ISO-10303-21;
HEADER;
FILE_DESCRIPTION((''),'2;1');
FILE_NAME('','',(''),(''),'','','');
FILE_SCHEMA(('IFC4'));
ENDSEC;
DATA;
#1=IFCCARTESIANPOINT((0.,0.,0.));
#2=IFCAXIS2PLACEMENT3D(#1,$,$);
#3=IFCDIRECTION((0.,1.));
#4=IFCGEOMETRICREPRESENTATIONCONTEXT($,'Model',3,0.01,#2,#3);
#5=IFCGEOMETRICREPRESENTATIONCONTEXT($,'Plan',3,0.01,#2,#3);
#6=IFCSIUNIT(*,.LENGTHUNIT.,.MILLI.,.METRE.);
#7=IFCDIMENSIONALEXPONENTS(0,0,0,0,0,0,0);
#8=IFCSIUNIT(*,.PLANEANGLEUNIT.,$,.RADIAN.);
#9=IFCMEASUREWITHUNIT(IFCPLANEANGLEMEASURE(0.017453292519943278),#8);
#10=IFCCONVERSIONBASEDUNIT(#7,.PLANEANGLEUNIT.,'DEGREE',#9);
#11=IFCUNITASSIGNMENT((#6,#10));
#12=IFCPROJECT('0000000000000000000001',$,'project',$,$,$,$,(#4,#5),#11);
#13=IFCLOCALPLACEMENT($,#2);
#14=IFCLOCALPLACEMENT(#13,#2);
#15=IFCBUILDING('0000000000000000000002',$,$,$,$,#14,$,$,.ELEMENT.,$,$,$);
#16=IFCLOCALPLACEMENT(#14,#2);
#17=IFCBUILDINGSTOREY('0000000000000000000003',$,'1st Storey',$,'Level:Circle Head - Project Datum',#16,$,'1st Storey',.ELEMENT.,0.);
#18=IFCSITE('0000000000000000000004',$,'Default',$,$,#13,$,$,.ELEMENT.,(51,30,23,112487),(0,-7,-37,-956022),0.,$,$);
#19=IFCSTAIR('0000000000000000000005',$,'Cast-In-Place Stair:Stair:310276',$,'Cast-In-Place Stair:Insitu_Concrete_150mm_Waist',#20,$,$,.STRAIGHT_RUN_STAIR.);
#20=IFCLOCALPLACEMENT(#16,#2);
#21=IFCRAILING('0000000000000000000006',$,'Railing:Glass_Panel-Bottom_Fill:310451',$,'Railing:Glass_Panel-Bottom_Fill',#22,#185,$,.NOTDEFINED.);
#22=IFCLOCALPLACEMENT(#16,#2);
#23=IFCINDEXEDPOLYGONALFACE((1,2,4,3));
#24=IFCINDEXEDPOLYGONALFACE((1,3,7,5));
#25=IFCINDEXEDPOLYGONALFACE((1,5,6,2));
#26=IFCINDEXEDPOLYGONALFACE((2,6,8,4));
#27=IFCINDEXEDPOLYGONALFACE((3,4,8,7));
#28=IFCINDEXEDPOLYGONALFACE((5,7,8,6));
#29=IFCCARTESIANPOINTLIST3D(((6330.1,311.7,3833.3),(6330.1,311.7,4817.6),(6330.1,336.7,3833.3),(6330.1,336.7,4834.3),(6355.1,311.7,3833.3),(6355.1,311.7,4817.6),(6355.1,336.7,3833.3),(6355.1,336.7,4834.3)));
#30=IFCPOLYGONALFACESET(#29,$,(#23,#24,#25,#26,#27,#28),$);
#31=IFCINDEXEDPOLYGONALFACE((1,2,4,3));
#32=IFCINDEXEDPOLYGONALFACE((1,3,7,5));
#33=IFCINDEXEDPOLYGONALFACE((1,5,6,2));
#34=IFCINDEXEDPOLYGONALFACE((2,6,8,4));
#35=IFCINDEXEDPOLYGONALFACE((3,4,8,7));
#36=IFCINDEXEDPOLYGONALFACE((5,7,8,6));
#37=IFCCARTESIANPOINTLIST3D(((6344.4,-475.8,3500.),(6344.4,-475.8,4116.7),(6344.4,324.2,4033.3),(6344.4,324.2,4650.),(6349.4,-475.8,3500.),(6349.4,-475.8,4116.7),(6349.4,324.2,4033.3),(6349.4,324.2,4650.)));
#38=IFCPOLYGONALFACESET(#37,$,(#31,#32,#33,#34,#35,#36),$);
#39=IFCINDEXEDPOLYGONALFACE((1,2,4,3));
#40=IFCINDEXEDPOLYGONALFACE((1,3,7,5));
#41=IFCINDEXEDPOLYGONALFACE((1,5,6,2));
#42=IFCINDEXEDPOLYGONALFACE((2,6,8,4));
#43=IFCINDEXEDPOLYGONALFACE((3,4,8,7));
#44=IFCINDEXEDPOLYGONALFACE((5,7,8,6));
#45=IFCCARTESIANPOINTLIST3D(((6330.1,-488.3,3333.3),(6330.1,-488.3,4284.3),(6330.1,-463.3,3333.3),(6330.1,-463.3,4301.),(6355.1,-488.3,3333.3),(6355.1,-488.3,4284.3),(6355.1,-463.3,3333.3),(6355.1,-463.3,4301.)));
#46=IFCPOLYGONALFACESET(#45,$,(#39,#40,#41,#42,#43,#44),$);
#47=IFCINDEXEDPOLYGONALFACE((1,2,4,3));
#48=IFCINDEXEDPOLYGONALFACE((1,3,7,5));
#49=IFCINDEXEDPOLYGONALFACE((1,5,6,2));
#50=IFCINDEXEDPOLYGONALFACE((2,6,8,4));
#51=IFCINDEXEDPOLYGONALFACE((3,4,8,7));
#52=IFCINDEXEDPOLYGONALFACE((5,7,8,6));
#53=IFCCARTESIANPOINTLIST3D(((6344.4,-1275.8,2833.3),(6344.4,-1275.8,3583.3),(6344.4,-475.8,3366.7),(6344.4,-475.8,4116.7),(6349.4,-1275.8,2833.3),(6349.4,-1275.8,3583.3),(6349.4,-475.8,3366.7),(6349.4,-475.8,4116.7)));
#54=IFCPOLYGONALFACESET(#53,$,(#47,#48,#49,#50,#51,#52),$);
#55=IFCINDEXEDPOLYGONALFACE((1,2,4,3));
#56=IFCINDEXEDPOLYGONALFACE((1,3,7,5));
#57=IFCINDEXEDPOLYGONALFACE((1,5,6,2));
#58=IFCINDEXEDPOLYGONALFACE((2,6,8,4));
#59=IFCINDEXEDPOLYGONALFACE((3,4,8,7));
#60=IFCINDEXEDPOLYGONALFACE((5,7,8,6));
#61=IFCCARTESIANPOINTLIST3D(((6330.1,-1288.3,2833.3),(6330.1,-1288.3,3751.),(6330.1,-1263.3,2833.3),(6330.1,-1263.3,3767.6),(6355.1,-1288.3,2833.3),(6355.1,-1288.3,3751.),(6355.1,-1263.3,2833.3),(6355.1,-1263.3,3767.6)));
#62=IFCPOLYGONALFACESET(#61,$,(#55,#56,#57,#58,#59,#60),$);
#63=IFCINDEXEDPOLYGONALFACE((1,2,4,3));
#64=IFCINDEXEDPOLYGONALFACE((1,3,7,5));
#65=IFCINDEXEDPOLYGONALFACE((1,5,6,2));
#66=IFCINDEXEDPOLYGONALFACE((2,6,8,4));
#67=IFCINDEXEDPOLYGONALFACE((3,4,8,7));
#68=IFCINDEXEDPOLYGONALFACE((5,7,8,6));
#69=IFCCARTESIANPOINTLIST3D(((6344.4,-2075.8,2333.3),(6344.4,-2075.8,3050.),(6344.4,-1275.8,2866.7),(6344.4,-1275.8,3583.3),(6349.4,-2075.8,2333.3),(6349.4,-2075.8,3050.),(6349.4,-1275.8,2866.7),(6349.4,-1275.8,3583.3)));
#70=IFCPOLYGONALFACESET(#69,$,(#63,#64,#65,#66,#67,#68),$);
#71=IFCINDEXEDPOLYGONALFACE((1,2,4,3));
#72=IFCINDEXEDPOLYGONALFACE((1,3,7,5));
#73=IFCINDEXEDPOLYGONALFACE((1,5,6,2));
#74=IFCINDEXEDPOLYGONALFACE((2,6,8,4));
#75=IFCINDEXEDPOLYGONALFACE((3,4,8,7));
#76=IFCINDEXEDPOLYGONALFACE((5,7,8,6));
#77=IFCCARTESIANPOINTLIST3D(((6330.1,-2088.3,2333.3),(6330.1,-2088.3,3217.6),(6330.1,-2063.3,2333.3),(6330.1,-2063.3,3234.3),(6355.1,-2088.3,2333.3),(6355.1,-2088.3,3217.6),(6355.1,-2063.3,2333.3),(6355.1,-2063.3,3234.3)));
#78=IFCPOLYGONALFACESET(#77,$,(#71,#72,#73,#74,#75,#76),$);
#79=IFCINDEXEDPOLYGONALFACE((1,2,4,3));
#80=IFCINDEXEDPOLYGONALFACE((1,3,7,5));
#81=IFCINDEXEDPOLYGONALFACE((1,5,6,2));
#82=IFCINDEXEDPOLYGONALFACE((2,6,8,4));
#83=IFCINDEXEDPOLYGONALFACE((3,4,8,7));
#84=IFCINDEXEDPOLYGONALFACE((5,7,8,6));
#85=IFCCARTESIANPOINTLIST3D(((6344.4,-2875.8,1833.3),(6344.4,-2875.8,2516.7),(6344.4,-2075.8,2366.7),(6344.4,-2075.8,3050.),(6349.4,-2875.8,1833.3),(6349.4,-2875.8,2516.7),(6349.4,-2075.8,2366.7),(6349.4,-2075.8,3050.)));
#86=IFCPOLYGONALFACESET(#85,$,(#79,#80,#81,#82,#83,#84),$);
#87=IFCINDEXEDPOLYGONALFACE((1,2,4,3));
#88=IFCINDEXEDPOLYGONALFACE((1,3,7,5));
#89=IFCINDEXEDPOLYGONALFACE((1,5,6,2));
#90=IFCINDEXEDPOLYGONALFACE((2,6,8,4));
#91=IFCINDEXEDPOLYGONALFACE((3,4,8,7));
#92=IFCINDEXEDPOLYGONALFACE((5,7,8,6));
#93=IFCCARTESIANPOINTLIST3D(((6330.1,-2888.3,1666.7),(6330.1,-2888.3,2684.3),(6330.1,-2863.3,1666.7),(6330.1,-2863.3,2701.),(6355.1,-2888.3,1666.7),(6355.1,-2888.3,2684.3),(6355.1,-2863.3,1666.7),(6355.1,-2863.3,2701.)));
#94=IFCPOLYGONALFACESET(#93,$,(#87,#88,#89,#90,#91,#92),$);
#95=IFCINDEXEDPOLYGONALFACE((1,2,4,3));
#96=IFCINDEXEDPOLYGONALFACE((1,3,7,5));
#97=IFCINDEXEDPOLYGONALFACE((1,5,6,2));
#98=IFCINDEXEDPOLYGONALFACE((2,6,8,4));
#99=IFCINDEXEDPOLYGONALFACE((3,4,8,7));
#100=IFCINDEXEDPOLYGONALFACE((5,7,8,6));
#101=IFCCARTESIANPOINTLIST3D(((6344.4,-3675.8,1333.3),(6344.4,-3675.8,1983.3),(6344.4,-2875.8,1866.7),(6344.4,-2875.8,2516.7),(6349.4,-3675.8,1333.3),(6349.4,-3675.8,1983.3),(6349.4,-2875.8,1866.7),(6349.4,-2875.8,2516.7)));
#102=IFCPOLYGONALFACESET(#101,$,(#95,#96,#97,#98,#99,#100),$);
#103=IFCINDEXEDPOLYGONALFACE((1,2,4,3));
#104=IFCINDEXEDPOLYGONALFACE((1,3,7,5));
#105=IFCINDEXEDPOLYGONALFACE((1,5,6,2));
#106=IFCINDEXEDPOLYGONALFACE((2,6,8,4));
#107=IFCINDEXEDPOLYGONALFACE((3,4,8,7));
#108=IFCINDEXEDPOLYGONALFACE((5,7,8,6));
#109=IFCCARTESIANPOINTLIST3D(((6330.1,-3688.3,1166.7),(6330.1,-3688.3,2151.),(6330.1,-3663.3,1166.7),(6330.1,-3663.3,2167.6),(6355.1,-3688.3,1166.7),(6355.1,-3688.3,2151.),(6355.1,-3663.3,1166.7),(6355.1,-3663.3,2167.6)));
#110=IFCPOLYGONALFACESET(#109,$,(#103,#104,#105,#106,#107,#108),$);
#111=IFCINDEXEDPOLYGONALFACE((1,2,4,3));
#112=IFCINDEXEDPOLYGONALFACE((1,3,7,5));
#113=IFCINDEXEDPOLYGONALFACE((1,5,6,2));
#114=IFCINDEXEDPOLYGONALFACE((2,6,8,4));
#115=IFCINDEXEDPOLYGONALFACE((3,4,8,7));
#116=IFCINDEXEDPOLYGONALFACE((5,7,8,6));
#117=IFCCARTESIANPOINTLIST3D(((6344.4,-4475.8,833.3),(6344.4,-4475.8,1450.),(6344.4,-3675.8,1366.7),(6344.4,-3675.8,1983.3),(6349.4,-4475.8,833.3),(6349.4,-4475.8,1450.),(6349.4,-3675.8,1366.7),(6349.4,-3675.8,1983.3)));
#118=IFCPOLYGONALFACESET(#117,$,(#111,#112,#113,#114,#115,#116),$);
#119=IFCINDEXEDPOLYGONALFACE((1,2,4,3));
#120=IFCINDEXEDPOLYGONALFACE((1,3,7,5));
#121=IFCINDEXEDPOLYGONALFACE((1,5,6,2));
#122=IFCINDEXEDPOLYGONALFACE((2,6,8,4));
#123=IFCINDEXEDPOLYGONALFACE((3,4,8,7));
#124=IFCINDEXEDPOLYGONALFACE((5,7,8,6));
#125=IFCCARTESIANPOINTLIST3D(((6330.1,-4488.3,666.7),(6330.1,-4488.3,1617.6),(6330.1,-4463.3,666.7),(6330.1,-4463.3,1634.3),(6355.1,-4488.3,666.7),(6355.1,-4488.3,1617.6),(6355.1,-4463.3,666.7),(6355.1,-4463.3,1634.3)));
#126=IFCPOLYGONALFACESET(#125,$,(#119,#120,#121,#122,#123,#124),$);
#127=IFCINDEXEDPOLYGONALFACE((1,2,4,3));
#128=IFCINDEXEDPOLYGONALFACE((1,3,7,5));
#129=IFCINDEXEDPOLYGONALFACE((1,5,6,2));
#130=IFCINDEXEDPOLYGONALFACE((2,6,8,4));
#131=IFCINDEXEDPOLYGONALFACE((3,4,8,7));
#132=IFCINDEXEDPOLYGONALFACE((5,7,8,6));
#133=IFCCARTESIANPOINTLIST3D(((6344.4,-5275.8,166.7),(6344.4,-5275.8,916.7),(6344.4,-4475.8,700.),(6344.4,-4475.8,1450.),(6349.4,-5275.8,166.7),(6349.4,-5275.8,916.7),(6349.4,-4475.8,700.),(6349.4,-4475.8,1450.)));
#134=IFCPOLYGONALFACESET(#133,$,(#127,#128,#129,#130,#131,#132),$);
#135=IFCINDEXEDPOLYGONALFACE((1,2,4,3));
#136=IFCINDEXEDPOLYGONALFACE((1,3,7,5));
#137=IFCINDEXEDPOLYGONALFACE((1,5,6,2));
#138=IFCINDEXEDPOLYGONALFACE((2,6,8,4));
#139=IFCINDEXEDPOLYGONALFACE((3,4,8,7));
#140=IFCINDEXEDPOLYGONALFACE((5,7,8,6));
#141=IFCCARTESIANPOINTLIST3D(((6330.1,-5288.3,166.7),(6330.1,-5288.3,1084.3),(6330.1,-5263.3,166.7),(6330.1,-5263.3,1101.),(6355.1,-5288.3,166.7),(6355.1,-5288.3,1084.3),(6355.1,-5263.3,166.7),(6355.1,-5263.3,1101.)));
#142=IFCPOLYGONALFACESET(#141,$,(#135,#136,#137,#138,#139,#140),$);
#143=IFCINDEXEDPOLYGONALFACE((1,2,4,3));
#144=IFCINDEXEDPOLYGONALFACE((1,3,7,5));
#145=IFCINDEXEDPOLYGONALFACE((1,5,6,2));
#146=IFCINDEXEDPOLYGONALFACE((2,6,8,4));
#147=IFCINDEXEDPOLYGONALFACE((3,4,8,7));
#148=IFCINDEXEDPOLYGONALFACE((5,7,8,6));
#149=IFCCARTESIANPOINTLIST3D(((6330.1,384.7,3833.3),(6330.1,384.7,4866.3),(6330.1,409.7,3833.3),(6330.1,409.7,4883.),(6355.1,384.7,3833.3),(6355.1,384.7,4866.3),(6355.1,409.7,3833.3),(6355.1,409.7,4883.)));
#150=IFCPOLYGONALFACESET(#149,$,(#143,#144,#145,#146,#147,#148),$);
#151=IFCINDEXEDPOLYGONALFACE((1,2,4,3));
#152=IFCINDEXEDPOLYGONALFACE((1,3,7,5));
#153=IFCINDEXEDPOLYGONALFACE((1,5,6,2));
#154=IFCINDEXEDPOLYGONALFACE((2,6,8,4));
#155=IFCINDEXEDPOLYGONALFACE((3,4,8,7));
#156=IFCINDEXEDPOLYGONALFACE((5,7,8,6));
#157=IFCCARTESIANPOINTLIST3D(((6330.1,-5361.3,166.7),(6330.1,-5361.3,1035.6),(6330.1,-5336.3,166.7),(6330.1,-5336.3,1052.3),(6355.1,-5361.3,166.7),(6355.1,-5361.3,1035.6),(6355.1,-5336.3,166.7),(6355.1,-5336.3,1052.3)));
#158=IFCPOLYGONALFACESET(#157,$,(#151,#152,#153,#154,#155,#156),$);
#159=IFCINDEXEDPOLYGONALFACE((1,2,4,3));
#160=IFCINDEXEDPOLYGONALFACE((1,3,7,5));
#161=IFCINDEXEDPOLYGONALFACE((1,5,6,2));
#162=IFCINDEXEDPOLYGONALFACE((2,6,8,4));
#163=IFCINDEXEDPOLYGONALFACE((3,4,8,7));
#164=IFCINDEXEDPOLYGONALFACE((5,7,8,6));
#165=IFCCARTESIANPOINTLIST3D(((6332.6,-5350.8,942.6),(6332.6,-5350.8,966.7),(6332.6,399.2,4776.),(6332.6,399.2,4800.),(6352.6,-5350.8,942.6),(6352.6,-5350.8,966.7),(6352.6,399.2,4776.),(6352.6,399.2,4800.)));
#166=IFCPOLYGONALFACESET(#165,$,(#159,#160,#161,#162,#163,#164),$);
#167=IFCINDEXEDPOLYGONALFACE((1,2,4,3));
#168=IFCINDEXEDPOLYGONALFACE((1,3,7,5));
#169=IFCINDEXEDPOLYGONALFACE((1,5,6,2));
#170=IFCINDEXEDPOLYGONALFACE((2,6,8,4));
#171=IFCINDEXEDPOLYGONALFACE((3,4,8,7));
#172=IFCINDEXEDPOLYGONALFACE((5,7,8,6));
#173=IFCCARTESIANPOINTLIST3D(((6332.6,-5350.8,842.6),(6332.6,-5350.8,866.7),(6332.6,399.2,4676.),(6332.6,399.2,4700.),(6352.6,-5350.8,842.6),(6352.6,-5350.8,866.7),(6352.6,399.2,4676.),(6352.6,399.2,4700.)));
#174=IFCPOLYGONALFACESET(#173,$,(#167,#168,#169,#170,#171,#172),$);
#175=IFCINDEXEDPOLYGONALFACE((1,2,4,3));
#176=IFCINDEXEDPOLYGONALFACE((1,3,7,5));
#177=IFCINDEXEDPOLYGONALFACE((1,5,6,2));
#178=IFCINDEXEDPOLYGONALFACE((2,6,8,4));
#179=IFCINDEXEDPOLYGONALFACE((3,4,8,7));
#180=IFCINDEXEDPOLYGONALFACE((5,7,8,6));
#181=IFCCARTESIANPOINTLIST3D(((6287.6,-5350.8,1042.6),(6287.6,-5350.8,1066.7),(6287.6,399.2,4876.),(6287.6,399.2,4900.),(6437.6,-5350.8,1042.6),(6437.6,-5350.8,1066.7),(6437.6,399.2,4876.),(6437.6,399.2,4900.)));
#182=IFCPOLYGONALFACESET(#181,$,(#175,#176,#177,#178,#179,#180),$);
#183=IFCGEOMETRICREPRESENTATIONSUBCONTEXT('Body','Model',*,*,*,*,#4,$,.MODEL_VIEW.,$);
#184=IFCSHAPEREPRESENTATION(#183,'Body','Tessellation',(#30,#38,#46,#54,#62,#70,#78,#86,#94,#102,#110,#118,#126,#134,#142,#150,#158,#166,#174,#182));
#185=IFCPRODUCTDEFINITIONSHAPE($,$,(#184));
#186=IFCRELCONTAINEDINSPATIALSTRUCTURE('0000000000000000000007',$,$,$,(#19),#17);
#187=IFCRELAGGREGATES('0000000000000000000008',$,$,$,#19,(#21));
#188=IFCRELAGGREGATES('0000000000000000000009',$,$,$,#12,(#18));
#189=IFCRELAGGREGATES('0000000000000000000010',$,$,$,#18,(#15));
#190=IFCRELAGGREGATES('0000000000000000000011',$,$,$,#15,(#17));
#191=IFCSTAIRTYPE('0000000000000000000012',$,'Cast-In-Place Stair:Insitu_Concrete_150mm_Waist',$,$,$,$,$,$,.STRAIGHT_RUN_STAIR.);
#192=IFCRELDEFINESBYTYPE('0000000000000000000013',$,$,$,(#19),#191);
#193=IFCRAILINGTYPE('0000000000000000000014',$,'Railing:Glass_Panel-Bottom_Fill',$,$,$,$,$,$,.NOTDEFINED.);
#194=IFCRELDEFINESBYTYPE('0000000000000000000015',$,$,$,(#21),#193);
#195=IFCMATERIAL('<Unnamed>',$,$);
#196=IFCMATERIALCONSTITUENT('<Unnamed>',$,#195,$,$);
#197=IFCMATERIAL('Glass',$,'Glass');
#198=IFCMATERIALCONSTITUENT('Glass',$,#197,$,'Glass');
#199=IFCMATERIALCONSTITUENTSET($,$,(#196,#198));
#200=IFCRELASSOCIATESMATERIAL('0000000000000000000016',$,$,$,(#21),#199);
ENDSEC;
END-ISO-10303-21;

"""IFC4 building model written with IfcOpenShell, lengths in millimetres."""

from ifc_helpers import new_model, entity, si_unit, converted_unit, direction, frame, origin, place, context, subcontext, project, spatial, indexed_curve, outline, extrude, material, constituent, constituent_set, type_object, element, aggregate, save


model = new_model("IFC4")

# Units and contexts
model_context = context("Model", 3, precision=0.01, world=origin(), true_north=direction((0.0, 1.0)))
plan_context = context("Plan", 3, precision=0.01, world=origin(), true_north=direction((0.0, 1.0)))
body_context = subcontext(model_context, "Body", "Model", "MODEL_VIEW")
ifc_project = project(units=[si_unit("LENGTHUNIT", "METRE", prefix="MILLI"), converted_unit("PLANEANGLEUNIT", "DEGREE", entity("IfcPlaneAngleMeasure", 0.017453292519943278), si_unit("PLANEANGLEUNIT", "RADIAN"), dimensions=[0, 0, 0, 0, 0, 0, 0])], contexts=[model_context, plan_context])

# Site, building, storey
site_placement = place(None, origin())
site = spatial("IfcSite", under=ifc_project, at=site_placement, Name="Default", CompositionType="ELEMENT", RefLatitude=(51, 30, 23, 112487), RefLongitude=(0, -7, -37, -956022), RefElevation=0.0)
building_placement = place(site_placement, origin())
building = spatial("IfcBuilding", under=site, at=building_placement, CompositionType="ELEMENT")
storey_placement = place(building_placement, origin())
storey = spatial("IfcBuildingStorey", under=building, at=storey_placement, Name="1st Storey", ObjectType="Level:Circle Head - Project Datum", LongName="1st Storey", CompositionType="ELEMENT", Elevation=0.0)

# Shared definitions
ifc_material_1 = material(Name="<Unnamed>")

# Stair, railing
stair_type_1 = type_object("IfcStairType", Name="Cast-In-Place Stair:Insitu_Concrete_150mm_Waist", PredefinedType="STRAIGHT_RUN_STAIR")
stair_1_placement = place(storey_placement, origin())
stair_1 = element("IfcStair", 1, at=stair_1_placement, inside=storey, type_object=stair_type_1, Name="Cast-In-Place Stair:Stair:310276", ObjectType="Cast-In-Place Stair:Insitu_Concrete_150mm_Waist", PredefinedType="STRAIGHT_RUN_STAIR")
ifc_constituent_1 = constituent(ifc_material_1, Name="<Unnamed>")
ifc_material_2 = material(Name="Glass", Category="Glass")
ifc_constituent_2 = constituent(ifc_material_2, Name="Glass", Category="Glass")
ifc_constituent_set_1 = constituent_set(constituents=[ifc_constituent_1, ifc_constituent_2])
railing_type = type_object("IfcRailingType", Name="Railing:Glass_Panel-Bottom_Fill", PredefinedType="NOTDEFINED")
railing_1_placement = place(stair_1_placement, frame((6287.6, -5361.3, 166.7)))
railing_1 = element("IfcRailing", 2, at=railing_1_placement, type_object=railing_type, material=ifc_constituent_set_1, Name="Railing:Glass_Panel-Bottom_Fill:310451", ObjectType="Railing:Glass_Panel-Bottom_Fill", PredefinedType="NOTDEFINED", context=body_context, shape_type="SweptSolid", body=[
    extrude(outline(indexed_curve([(-12.5, -496.3), (12.5, -496.3), (12.5, 504.6), (-12.5, 488.0), (-12.5, -496.3)], self_intersect=False)), frame((42.5, 5685.5, 4163.0), z_axis=(1.0, 0.0, 0.0), x_axis=(0.0, 1.0, 0.0)), (0.0, 0.0, 1.0), 25.0),
    extrude(outline(indexed_curve([(-41.7, -400.0), (575.0, -400.0), (41.7, 400.0), (-575.0, 400.0), (-41.7, -400.0)], self_intersect=False)), frame((56.7, 5285.5, 3908.3), z_axis=(1.0, 0.0, 0.0), x_axis=(0.0, 0.0, -1.0)), (0.0, 0.0, 1.0), 5.0),
    extrude(outline(indexed_curve([(-12.5, -479.6), (12.5, -479.6), (12.5, 488.0), (-12.5, 471.3), (-12.5, -479.6)], self_intersect=False)), frame((42.5, 4885.5, 3646.3), z_axis=(1.0, 0.0, 0.0), x_axis=(0.0, 1.0, 0.0)), (0.0, 0.0, 1.0), 25.0),
    extrude(outline(indexed_curve([(-108.3, -400.0), (641.7, -400.0), (108.3, 400.0), (-641.7, 400.0), (-108.3, -400.0)], self_intersect=False)), frame((56.7, 4485.5, 3308.3), z_axis=(1.0, 0.0, 0.0), x_axis=(0.0, 0.0, -1.0)), (0.0, 0.0, 1.0), 5.0),
    extrude(outline(indexed_curve([(-12.5, -463.0), (12.5, -463.0), (12.5, 471.3), (-12.5, 454.6), (-12.5, -463.0)], self_intersect=False)), frame((42.5, 4085.5, 3129.6), z_axis=(1.0, 0.0, 0.0), x_axis=(0.0, 1.0, 0.0)), (0.0, 0.0, 1.0), 25.0),
    extrude(outline(indexed_curve([(-91.7, -400.0), (625.0, -400.0), (91.7, 400.0), (-625.0, 400.0), (-91.7, -400.0)], self_intersect=False)), frame((56.7, 3685.5, 2791.7), z_axis=(1.0, 0.0, 0.0), x_axis=(0.0, 0.0, -1.0)), (0.0, 0.0, 1.0), 5.0),
    extrude(outline(indexed_curve([(-12.5, -446.3), (12.5, -446.3), (12.5, 454.6), (-12.5, 438.0), (-12.5, -446.3)], self_intersect=False)), frame((42.5, 3285.5, 2613.0), z_axis=(1.0, 0.0, 0.0), x_axis=(0.0, 1.0, 0.0)), (0.0, 0.0, 1.0), 25.0),
    extrude(outline(indexed_curve([(-75.0, -400.0), (608.3, -400.0), (75.0, 400.0), (-608.3, 400.0), (-75.0, -400.0)], self_intersect=False)), frame((56.7, 2885.5, 2275.0), z_axis=(1.0, 0.0, 0.0), x_axis=(0.0, 0.0, -1.0)), (0.0, 0.0, 1.0), 5.0),
    extrude(outline(indexed_curve([(-12.5, -513.0), (12.5, -513.0), (12.5, 521.3), (-12.5, 504.6), (-12.5, -513.0)], self_intersect=False)), frame((42.5, 2485.5, 2013.0), z_axis=(1.0, 0.0, 0.0), x_axis=(0.0, 1.0, 0.0)), (0.0, 0.0, 1.0), 25.0),
    extrude(outline(indexed_curve([(-58.3, -400.0), (591.7, -400.0), (58.3, 400.0), (-591.7, 400.0), (-58.3, -400.0)], self_intersect=False)), frame((56.7, 2085.5, 1758.3), z_axis=(1.0, 0.0, 0.0), x_axis=(0.0, 0.0, -1.0)), (0.0, 0.0, 1.0), 5.0),
    extrude(outline(indexed_curve([(-12.5, -496.3), (12.5, -496.3), (12.5, 504.6), (-12.5, 488.0), (-12.5, -496.3)], self_intersect=False)), frame((42.5, 1685.5, 1496.3), z_axis=(1.0, 0.0, 0.0), x_axis=(0.0, 1.0, 0.0)), (0.0, 0.0, 1.0), 25.0),
    extrude(outline(indexed_curve([(-41.7, -400.0), (575.0, -400.0), (41.7, 400.0), (-575.0, 400.0), (-41.7, -400.0)], self_intersect=False)), frame((56.7, 1285.5, 1241.7), z_axis=(1.0, 0.0, 0.0), x_axis=(0.0, 0.0, -1.0)), (0.0, 0.0, 1.0), 5.0),
    extrude(outline(indexed_curve([(-12.5, -479.6), (12.5, -479.6), (12.5, 488.0), (-12.5, 471.3), (-12.5, -479.6)], self_intersect=False)), frame((42.5, 885.5, 979.6), z_axis=(1.0, 0.0, 0.0), x_axis=(0.0, 1.0, 0.0)), (0.0, 0.0, 1.0), 25.0),
    extrude(outline(indexed_curve([(-108.3, -400.0), (641.7, -400.0), (108.3, 400.0), (-641.7, 400.0), (-108.3, -400.0)], self_intersect=False)), frame((56.7, 485.5, 641.7), z_axis=(1.0, 0.0, 0.0), x_axis=(0.0, 0.0, -1.0)), (0.0, 0.0, 1.0), 5.0),
    extrude(outline(indexed_curve([(-12.5, -463.0), (12.5, -463.0), (12.5, 471.3), (-12.5, 454.6), (-12.5, -463.0)], self_intersect=False)), frame((42.5, 85.5, 463.0), z_axis=(1.0, 0.0, 0.0), x_axis=(0.0, 1.0, 0.0)), (0.0, 0.0, 1.0), 25.0),
    extrude(outline(indexed_curve([(-12.5, -520.6), (12.5, -520.6), (12.5, 529.0), (-12.5, 512.3), (-12.5, -520.6)], self_intersect=False)), frame((42.5, 5758.5, 4187.3), z_axis=(1.0, 0.0, 0.0), x_axis=(0.0, 1.0, 0.0)), (0.0, 0.0, 1.0), 25.0),
    extrude(outline(indexed_curve([(-12.5, -438.6), (12.5, -438.6), (12.5, 447.0), (-12.5, 430.3), (-12.5, -438.6)], self_intersect=False)), frame((42.5, 12.5, 438.6), z_axis=(1.0, 0.0, 0.0), x_axis=(0.0, 1.0, 0.0)), (0.0, 0.0, 1.0), 25.0),
    extrude(outline(indexed_curve([(-3462.0, -10.0), (3448.7, -10.0), (3462.0, 10.0), (-3448.7, 10.0), (-3462.0, -10.0)], self_intersect=False)), frame((45.0, 2885.5, 2704.6), z_axis=(1.0, 0.0, 0.0), x_axis=(0.0, 0.83205, 0.5547)), (0.0, 0.0, 1.0), 20.0),
    extrude(outline(indexed_curve([(-3462.0, -10.0), (3448.7, -10.0), (3462.0, 10.0), (-3448.7, 10.0), (-3462.0, -10.0)], self_intersect=False)), frame((45.0, 2885.5, 2604.6), z_axis=(1.0, 0.0, 0.0), x_axis=(0.0, 0.83205, 0.5547)), (0.0, 0.0, 1.0), 20.0),
    extrude(outline(indexed_curve([(-3462.0, -10.0), (3448.7, -10.0), (3462.0, 10.0), (-3448.7, 10.0), (-3462.0, -10.0)], self_intersect=False)), frame((0.0, 2885.5, 2804.6), z_axis=(1.0, 0.0, 0.0), x_axis=(0.0, 0.83205, 0.5547)), (0.0, 0.0, 1.0), 150.0),
])
aggregate(stair_1, [railing_1])

save(model, "model.ifc")
